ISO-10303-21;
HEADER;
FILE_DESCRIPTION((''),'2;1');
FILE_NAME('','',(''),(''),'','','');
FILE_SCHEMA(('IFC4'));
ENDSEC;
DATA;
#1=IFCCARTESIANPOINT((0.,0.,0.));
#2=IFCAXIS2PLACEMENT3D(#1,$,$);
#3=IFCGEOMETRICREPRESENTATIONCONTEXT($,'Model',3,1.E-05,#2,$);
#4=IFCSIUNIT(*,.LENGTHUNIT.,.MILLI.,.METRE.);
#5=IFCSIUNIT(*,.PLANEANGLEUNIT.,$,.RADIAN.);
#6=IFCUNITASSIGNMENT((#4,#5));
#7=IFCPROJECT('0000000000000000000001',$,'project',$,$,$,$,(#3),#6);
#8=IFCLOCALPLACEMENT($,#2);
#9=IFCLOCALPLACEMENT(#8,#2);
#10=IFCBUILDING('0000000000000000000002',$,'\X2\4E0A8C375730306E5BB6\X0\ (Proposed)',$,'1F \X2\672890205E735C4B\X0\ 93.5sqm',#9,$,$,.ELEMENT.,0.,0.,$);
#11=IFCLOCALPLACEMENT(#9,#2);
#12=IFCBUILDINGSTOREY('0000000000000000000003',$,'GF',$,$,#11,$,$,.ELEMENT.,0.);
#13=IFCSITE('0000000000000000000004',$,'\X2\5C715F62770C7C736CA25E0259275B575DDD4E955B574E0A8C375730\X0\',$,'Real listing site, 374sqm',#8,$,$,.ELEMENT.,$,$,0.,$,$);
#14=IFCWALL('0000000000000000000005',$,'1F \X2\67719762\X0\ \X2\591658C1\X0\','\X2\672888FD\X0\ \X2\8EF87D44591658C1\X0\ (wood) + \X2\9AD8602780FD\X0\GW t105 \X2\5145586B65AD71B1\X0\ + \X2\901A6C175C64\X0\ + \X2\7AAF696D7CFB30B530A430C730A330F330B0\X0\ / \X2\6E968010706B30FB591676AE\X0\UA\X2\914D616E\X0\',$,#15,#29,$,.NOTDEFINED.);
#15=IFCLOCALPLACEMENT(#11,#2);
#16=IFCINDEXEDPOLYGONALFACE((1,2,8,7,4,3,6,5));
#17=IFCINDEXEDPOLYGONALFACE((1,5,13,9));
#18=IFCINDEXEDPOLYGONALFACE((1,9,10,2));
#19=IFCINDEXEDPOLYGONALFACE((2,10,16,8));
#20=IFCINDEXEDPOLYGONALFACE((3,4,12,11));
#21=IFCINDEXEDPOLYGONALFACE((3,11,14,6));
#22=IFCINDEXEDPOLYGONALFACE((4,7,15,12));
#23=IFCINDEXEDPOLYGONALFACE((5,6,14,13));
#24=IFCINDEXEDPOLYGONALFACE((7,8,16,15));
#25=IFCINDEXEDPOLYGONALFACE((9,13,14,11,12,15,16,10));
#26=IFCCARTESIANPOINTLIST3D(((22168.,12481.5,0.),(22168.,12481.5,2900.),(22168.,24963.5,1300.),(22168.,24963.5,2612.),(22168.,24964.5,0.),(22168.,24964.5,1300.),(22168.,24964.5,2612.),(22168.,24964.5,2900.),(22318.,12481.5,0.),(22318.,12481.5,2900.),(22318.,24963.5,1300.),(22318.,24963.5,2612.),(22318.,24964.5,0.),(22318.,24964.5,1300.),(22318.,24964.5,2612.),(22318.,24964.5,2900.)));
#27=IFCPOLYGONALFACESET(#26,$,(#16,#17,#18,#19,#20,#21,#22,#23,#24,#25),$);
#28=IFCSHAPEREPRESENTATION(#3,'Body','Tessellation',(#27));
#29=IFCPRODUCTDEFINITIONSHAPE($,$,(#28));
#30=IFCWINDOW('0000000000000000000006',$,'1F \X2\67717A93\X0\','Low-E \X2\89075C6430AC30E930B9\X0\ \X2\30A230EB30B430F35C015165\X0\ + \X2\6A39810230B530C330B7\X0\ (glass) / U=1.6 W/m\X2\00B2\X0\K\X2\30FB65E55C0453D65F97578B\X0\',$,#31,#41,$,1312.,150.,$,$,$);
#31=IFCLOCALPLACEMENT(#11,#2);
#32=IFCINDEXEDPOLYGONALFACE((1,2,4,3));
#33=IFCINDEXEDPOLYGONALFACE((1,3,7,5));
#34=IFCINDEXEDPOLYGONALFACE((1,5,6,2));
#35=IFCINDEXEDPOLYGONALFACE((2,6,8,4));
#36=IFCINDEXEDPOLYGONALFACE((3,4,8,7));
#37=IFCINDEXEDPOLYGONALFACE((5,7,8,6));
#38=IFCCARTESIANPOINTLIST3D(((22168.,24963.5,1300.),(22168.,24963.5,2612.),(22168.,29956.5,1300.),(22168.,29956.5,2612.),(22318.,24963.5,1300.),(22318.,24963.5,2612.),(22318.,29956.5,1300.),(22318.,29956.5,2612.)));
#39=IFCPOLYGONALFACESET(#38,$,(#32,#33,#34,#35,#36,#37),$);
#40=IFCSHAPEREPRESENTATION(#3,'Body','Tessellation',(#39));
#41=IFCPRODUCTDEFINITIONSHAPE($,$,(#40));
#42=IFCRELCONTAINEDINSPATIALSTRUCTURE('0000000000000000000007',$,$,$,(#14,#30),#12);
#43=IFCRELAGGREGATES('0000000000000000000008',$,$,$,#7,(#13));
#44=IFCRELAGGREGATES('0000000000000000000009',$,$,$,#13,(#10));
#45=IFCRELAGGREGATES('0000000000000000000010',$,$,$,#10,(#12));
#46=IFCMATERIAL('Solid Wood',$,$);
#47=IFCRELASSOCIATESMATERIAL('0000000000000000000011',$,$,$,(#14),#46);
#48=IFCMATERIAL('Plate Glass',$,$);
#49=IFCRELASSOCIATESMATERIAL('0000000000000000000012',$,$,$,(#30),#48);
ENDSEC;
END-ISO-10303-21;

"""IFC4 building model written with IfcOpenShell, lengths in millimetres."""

from ifc_helpers import new_model, si_unit, frame, frame_2d, origin, place, context, project, spatial, rectangle, extrude, material, element, fill, save


model = new_model("IFC4")

# Units and contexts
model_context = context("Model", 3, precision=1e-05, world=origin())
ifc_project = project(units=[si_unit("LENGTHUNIT", "METRE", prefix="MILLI"), si_unit("PLANEANGLEUNIT", "RADIAN")], contexts=[model_context])

# Site, building, storey
site_placement = place(None, origin())
site = spatial("IfcSite", under=ifc_project, at=site_placement, Name="山形県米沢市大字川井字上谷地", ObjectType="Real listing site, 374sqm", CompositionType="ELEMENT", RefElevation=0.0)
building_placement = place(site_placement, origin())
building = spatial("IfcBuilding", under=site, at=building_placement, Name="上谷地の家 (Proposed)", ObjectType="1F 木造平屋 93.5sqm", CompositionType="ELEMENT", ElevationOfRefHeight=0.0, ElevationOfTerrain=0.0)
storey_placement = place(building_placement, origin())
storey = spatial("IfcBuildingStorey", under=building, at=storey_placement, Name="GF", CompositionType="ELEMENT", Elevation=0.0)

# Shared definitions
ifc_material_1 = material(Name="Solid Wood")

# Shared definitions
ifc_material_2 = material(Name="Plate Glass")

# Wall, opening, window
wall_1_placement = place(storey_placement, frame((11084.0, 6241.0, 0.0)))
wall_1 = element("IfcWall", 1, at=wall_1_placement, inside=storey, material=ifc_material_1, Name="1F 東面 外壁", Description="木製 軸組外壁 (wood) + 高性能GW t105 充填断熱 + 通気層 + 窯業系サイディング / 準耐火・外皮UA配慮", PredefinedType="NOTDEFINED", context=model_context, shape_type="SweptSolid", body=[
    extrude(rectangle(XDim=150.0, YDim=12483.0, at=frame_2d((75.0, 6241.0))), frame((11084.0, 6241.0, 0.0)), (0.0, 0.0, 1.0), 2900.0),
])
opening_1_placement = place(storey_placement, frame((11084.0, 12482.0, 650.0)))
opening_1 = element("IfcOpeningElement", 2, at=opening_1_placement, cuts=wall_1, PredefinedType="NOTDEFINED", context=model_context, shape_type="SweptSolid", body=[
    extrude(rectangle(XDim=150.0, YDim=4993.0, at=frame_2d((75.0, 2496.0))), frame((11084.0, 12482.0, 650.0)), (0.0, 0.0, 1.0), 1312.0),
])
window_1_placement = place(storey_placement, frame((11084.0, 12482.0, 650.0)))
window_1 = element("IfcWindow", 3, at=window_1_placement, inside=storey, material=ifc_material_2, Name="1F 東窓", Description="Low-E 複層ガラス アルゴン封入 + 樹脂サッシ (glass) / U=1.6 W/m²K・日射取得型", OverallHeight=1312.0, OverallWidth=150.0, context=model_context, shape_type="SweptSolid", body=[
    extrude(rectangle(XDim=150.0, YDim=4993.0, at=frame_2d((75.0, 2496.0))), frame((11084.0, 12482.0, 650.0)), (0.0, 0.0, 1.0), 1312.0),
])
fill(opening_1, window_1)

save(model, "model.ifc")
